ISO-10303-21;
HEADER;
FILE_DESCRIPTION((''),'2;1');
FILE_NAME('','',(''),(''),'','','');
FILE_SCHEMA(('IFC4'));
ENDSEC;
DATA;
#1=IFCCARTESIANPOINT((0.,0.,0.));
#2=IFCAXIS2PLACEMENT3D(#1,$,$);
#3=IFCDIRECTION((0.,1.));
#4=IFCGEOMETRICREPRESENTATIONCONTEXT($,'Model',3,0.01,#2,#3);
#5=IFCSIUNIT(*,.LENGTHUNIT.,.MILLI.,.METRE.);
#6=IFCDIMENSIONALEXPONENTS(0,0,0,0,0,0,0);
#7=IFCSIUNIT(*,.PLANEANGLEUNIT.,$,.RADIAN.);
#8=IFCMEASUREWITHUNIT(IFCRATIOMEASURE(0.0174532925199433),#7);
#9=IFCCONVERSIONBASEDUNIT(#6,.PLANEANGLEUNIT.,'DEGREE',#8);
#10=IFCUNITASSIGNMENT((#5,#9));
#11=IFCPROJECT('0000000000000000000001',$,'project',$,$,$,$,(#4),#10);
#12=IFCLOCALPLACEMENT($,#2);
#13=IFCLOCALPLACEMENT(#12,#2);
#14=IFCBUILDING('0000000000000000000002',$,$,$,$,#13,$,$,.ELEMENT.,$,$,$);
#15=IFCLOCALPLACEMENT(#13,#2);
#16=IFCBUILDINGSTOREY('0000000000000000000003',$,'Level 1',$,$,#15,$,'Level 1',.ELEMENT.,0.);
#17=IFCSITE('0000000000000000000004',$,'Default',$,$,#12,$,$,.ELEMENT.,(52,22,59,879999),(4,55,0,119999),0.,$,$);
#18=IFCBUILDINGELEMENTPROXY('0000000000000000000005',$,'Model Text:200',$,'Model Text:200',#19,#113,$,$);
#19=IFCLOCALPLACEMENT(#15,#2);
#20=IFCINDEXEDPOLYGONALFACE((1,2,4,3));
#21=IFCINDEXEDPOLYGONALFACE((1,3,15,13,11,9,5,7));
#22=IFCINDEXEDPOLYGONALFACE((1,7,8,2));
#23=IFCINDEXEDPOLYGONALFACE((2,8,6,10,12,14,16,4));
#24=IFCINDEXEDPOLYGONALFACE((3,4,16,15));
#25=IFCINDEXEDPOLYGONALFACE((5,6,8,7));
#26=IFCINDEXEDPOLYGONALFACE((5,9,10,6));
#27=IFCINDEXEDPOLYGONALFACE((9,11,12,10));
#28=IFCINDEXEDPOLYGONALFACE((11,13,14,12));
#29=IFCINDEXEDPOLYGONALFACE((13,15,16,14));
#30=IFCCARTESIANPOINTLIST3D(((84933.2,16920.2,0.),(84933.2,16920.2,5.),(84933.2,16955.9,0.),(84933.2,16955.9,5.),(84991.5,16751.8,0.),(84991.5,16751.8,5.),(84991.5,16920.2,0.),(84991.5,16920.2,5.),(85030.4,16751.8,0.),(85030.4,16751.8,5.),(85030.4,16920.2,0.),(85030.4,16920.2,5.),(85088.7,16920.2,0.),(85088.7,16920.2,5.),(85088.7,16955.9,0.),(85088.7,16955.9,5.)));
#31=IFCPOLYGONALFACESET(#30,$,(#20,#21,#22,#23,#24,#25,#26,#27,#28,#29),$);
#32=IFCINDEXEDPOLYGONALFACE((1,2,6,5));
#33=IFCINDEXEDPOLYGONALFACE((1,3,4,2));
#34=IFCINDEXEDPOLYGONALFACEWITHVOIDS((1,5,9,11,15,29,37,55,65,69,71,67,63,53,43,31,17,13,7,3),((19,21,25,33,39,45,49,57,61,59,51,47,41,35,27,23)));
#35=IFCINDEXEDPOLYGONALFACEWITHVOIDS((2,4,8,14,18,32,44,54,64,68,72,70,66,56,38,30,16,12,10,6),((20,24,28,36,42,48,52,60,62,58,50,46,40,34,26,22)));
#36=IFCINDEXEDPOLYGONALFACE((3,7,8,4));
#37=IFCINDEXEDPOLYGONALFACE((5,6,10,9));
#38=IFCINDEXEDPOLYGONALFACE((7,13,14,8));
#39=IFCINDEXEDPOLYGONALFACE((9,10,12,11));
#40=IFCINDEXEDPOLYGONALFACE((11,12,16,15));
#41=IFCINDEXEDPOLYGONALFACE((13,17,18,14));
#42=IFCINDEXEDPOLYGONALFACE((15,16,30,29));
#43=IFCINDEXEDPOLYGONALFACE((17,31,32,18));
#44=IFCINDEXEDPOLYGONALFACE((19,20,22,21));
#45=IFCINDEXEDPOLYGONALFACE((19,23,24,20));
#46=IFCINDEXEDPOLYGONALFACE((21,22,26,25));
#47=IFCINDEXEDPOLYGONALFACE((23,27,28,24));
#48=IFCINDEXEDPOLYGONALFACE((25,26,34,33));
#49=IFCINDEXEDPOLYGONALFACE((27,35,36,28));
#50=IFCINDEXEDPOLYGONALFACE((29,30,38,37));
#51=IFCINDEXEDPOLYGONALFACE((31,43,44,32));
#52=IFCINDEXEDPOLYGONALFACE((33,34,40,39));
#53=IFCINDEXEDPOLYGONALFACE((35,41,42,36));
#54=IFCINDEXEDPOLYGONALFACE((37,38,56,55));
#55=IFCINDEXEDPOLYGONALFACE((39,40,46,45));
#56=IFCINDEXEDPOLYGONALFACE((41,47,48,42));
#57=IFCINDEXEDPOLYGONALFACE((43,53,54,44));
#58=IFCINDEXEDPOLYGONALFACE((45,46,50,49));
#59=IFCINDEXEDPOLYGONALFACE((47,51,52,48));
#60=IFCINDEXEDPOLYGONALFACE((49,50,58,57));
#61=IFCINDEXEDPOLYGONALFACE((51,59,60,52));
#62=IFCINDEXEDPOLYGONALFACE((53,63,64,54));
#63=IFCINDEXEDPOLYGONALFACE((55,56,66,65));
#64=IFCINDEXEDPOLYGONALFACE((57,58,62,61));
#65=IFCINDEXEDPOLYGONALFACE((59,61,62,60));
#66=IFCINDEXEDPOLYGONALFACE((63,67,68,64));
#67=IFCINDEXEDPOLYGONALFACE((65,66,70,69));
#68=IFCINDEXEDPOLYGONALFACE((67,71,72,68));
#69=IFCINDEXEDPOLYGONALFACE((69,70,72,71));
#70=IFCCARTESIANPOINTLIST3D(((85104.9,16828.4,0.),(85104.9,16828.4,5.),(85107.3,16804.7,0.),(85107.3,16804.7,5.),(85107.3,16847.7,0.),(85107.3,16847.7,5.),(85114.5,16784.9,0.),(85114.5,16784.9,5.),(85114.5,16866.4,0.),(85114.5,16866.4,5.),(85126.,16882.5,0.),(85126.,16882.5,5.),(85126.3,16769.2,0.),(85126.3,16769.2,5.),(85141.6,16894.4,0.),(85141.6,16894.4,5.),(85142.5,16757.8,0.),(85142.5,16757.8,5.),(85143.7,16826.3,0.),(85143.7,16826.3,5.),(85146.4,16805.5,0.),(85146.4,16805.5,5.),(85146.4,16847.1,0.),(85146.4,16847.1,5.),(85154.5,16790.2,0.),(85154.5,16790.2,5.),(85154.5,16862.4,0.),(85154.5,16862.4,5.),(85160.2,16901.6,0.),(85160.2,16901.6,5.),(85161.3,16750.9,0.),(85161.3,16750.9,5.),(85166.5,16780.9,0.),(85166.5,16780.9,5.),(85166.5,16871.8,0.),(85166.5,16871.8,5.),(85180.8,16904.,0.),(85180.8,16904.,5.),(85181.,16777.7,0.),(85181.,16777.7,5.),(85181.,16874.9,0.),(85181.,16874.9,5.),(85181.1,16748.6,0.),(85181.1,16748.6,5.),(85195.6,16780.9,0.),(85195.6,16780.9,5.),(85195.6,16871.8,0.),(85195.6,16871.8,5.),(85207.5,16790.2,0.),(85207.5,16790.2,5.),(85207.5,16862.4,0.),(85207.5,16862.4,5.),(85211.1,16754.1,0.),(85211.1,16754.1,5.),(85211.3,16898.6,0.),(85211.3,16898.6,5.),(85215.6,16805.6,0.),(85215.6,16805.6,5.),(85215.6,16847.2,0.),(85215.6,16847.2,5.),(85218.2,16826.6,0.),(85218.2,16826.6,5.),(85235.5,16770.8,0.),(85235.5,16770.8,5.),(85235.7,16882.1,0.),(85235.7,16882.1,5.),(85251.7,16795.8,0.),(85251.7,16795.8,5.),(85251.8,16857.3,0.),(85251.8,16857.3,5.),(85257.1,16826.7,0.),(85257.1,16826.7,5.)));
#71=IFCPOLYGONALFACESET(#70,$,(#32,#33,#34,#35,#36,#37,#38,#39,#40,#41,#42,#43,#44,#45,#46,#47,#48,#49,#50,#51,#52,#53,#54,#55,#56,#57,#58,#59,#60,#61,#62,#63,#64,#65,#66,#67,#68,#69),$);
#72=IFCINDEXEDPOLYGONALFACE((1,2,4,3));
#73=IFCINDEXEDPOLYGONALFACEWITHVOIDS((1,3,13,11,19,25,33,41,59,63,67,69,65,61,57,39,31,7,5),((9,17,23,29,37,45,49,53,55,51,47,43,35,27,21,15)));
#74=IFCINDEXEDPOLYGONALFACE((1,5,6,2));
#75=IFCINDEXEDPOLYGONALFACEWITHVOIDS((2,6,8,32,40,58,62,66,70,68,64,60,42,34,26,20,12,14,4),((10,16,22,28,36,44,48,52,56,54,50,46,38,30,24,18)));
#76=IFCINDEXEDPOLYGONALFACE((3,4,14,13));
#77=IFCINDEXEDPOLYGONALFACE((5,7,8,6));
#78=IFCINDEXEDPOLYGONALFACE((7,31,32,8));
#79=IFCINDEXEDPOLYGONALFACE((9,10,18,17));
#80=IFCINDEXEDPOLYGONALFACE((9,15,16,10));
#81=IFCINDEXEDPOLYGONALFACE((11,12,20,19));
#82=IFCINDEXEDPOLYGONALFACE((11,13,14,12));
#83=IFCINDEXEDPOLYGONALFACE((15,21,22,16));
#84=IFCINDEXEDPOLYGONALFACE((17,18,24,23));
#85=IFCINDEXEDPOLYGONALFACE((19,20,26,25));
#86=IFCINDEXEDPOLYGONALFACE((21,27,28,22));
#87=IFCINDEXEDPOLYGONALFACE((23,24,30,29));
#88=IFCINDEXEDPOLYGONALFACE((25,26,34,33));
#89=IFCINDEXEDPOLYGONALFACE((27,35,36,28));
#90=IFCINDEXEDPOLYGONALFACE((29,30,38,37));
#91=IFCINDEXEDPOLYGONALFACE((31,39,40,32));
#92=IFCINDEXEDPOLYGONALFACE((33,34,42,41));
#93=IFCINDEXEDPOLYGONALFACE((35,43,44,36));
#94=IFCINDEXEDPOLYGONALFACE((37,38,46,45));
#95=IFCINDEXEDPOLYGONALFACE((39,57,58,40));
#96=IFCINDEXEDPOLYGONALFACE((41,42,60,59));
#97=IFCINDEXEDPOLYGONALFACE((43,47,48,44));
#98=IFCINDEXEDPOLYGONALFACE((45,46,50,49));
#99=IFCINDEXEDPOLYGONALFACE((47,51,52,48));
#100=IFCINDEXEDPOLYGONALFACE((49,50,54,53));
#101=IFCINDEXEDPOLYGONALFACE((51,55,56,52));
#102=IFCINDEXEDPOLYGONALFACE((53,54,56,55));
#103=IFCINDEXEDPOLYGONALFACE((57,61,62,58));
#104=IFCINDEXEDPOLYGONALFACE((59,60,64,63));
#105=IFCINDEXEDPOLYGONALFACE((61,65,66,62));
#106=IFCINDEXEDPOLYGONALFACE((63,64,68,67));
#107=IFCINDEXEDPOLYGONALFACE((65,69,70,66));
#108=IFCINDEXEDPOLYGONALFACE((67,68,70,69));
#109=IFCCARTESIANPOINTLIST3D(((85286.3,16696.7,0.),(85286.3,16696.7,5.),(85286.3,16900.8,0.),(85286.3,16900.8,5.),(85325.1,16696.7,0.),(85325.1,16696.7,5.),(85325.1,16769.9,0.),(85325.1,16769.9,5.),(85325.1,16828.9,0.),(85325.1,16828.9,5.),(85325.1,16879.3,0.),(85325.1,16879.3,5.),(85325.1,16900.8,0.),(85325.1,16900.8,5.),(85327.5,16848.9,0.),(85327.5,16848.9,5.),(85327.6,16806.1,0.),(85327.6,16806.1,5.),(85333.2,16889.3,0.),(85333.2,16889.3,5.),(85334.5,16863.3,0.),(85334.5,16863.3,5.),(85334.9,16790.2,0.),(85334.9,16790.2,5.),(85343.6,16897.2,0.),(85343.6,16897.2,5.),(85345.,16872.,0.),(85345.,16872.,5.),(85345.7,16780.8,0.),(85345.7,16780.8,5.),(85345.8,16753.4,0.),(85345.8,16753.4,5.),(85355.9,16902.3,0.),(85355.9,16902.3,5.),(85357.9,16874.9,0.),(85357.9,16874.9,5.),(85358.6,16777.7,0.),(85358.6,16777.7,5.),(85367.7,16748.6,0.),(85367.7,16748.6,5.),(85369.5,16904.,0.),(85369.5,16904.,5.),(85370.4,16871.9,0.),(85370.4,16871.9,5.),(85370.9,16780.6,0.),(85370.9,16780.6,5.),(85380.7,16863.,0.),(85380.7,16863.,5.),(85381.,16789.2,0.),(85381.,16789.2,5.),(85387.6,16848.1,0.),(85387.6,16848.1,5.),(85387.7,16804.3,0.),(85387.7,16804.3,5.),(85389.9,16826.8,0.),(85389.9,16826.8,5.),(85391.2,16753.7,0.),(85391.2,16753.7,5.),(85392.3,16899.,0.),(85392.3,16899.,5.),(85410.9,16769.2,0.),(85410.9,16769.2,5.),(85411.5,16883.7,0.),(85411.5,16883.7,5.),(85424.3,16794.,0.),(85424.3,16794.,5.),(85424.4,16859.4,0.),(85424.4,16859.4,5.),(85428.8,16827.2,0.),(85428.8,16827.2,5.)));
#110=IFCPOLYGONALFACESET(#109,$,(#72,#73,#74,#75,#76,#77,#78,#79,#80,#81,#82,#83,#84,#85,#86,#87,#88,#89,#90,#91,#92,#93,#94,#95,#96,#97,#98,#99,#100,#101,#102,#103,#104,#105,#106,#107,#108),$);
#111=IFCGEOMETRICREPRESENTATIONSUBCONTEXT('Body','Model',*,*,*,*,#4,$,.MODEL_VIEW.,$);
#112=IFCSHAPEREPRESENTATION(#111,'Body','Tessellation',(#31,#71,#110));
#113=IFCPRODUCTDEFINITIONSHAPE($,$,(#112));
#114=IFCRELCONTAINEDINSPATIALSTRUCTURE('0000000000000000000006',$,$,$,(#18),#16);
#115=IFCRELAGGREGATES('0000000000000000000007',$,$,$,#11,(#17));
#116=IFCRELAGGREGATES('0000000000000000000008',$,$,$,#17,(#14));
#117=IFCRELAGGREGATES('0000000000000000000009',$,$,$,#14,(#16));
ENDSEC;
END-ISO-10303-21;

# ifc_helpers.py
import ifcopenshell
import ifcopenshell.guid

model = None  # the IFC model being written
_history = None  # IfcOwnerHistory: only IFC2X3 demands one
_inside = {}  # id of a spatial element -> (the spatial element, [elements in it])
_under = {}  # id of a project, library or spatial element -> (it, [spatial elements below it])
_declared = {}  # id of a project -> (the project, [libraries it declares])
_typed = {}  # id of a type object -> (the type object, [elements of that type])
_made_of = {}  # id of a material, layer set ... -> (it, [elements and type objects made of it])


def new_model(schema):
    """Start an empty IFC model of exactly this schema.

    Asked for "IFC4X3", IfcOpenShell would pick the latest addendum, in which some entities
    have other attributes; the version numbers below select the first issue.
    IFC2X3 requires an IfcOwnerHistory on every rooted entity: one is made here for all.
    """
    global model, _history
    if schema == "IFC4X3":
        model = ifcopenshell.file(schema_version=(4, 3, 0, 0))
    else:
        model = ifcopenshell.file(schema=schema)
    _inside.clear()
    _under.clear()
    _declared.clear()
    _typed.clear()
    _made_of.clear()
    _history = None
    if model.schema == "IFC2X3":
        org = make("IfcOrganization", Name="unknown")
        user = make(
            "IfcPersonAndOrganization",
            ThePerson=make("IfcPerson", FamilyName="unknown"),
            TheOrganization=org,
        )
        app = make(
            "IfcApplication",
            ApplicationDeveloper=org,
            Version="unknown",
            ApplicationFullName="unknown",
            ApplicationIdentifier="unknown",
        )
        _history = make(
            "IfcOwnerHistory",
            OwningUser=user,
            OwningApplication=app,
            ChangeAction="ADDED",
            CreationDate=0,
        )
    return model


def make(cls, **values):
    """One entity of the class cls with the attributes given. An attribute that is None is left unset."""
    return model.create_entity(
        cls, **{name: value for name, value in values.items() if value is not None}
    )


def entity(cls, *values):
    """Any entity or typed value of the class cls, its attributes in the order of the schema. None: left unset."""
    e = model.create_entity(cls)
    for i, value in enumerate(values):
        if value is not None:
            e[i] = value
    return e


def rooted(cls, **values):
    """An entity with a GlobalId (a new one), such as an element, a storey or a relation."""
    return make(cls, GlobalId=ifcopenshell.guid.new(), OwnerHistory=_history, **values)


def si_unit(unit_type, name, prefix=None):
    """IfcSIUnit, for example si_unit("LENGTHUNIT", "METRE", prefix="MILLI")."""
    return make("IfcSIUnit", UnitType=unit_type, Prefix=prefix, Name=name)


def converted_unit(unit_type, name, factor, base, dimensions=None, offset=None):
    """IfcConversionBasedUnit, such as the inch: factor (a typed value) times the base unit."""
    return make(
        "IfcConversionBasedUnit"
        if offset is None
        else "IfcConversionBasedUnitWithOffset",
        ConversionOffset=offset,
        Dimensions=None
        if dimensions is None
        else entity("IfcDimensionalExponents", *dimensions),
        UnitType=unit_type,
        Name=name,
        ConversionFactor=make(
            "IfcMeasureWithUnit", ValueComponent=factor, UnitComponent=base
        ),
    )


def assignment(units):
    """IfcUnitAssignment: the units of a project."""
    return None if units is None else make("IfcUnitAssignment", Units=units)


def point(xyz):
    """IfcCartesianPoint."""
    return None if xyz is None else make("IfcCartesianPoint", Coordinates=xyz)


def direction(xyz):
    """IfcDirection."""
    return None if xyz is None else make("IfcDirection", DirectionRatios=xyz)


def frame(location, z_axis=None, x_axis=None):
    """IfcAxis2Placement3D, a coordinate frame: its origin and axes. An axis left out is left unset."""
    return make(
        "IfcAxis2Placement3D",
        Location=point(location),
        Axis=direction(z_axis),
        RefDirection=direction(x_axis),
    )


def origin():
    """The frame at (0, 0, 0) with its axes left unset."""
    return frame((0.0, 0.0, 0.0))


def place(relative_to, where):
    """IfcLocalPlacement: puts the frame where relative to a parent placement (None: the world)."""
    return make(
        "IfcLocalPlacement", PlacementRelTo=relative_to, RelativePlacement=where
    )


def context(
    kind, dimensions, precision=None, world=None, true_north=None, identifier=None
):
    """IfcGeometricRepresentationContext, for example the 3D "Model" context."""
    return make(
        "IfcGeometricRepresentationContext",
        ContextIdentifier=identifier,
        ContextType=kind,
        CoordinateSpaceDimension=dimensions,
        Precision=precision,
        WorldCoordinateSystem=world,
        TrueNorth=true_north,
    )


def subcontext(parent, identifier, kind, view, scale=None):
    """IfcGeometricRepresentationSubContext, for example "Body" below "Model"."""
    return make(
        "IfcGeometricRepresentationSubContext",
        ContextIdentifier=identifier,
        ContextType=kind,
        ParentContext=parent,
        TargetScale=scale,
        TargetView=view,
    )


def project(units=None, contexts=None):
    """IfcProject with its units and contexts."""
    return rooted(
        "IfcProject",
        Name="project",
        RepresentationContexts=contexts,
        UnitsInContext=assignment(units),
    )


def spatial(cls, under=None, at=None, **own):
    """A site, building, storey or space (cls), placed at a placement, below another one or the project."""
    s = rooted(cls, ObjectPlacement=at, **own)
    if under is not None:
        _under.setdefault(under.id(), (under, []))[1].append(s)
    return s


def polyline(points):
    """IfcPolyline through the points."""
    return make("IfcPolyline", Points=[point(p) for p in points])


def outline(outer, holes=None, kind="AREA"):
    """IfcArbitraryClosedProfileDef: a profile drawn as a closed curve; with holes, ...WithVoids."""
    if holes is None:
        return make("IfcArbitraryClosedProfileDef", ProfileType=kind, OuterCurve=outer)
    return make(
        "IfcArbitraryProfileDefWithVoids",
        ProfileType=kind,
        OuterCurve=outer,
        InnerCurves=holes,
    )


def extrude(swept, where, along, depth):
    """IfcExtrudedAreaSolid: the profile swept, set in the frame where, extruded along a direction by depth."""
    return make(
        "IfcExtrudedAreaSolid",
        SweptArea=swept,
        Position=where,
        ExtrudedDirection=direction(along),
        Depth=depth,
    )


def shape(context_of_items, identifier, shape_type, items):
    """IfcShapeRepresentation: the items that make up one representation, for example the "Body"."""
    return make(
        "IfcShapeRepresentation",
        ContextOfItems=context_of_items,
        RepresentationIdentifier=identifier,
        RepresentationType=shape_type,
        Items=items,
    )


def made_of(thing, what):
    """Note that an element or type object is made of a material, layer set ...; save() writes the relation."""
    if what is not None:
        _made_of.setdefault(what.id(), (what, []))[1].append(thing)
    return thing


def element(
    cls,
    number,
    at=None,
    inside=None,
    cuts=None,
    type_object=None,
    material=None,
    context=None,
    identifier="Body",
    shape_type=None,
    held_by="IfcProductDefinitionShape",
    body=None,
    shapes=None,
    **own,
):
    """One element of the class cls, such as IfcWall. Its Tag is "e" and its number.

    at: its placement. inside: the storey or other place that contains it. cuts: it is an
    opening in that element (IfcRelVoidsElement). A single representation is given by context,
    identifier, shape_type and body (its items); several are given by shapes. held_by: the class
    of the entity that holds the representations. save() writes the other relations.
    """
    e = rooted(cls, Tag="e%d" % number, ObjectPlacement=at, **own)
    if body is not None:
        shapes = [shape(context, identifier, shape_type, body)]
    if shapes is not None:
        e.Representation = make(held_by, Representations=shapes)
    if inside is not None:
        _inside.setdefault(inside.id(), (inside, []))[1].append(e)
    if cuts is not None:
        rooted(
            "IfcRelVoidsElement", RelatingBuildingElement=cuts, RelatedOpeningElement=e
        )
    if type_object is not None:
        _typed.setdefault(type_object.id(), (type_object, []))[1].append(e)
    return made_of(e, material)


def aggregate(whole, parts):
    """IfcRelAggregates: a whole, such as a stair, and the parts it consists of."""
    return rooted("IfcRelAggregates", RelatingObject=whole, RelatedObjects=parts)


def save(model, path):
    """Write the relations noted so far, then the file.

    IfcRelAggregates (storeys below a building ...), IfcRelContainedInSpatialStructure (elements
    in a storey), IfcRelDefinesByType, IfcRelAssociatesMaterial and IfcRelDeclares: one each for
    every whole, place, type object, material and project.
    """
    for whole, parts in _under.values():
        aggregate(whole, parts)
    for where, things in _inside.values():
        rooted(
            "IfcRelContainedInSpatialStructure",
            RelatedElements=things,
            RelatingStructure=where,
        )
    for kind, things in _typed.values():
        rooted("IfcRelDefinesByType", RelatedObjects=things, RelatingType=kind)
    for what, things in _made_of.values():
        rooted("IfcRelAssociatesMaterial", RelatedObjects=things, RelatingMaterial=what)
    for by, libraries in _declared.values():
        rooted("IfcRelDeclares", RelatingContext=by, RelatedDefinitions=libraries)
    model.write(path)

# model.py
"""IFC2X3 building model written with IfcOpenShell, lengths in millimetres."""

from ifc_helpers import new_model, entity, si_unit, converted_unit, direction, frame, origin, place, context, subcontext, project, spatial, polyline, outline, extrude, element, save


model = new_model("IFC2X3")

# Units and contexts
model_context = context("Model", 3, precision=0.01, world=origin(), true_north=direction((0.0, 1.0)))
body_context = subcontext(model_context, "Body", "Model", "MODEL_VIEW")
ifc_project = project(units=[si_unit("LENGTHUNIT", "METRE", prefix="MILLI"), converted_unit("PLANEANGLEUNIT", "DEGREE", entity("IfcRatioMeasure", 0.0174532925199433), si_unit("PLANEANGLEUNIT", "RADIAN"), dimensions=[0, 0, 0, 0, 0, 0, 0])], contexts=[model_context])

# Site, building, storey
site_placement = place(None, origin())
site = spatial("IfcSite", under=ifc_project, at=site_placement, Name="Default", CompositionType="ELEMENT", RefLatitude=(52, 22, 59, 879999), RefLongitude=(4, 55, 0, 119999), RefElevation=0.0)
building_placement = place(site_placement, origin())
building = spatial("IfcBuilding", under=site, at=building_placement, CompositionType="ELEMENT")
storey_placement = place(building_placement, origin())
storey = spatial("IfcBuildingStorey", under=building, at=storey_placement, Name="Level 1", LongName="Level 1", CompositionType="ELEMENT", Elevation=0.0)

# Building element proxy
proxy_1_placement = place(building_placement, origin())
element("IfcBuildingElementProxy", 1, at=proxy_1_placement, inside=storey, Name="Model Text:200", ObjectType="Model Text:200", context=body_context, shape_type="SweptSolid", body=[
    extrude(outline(polyline([(-19.4, -135.2), (19.4, -135.2), (19.4, 33.2), (77.7, 33.2), (77.7, 68.8), (-77.7, 68.8), (-77.7, 33.2), (-19.4, 33.2), (-19.4, -135.2)])), frame((85010.9, 16887.0, 0.0)), (0.0, 0.0, 1.0), 5.0),
    extrude(outline(polyline([(-8.8, -65.7), (15.1, -65.7), (35.5, -60.5), (52.3, -50.4), (65.3, -35.4), (74.1, -17.3), (78.4, 2.1), (75.9, 32.5), (61.8, 58.5), (38.4, 77.1), (8.3, 85.6), (-22.7, 83.3), (-49.0, 69.9), (-67.8, 47.3), (-76.3, 17.5), (-76.0, -3.3), (-70.7, -22.5), (-60.5, -39.2), (-45.5, -52.3), (-27.7, -61.4), (-8.8, -65.7)]), holes=[polyline([(-2.7, -27.2), (-23.1, -22.5), (-37.5, -12.9), (-45.7, 0.0), (-47.3, 14.8), (-42.7, 28.9), (-32.2, 39.9), (-16.3, 46.3), (4.5, 46.9), (25.1, 42.1), (39.6, 32.6), (47.7, 19.7), (49.4, 5.0), (44.8, -9.2), (34.2, -20.2), (18.2, -26.7), (-2.7, -27.2)])]), frame((85171.1, 16826.3, 0.0), z_axis=(0.0, 0.0, 1.0), x_axis=(0.100608, -0.994926, 0.0)), (0.0, 0.0, 1.0), 5.0),
    extrude(outline(polyline([(-73.1, -75.4), (130.9, -75.4), (130.9, -36.6), (57.8, -36.6), (74.3, -15.9), (79.1, 6.0), (73.9, 29.5), (58.4, 49.2), (33.6, 62.6), (0.5, 67.1), (-31.8, 62.8), (-56.1, 49.8), (-71.3, 30.7), (-76.4, 7.8), (-74.7, -5.8), (-69.6, -18.1), (-61.7, -28.5), (-51.7, -36.6), (-73.1, -36.6), (-73.1, -75.4)]), holes=[polyline([(-1.2, -36.6), (-21.2, -34.2), (-35.6, -27.2), (-44.3, -16.7), (-47.2, -3.8), (-44.3, 8.7), (-35.4, 19.0), (-20.4, 25.9), (0.8, 28.2), (23.3, 26.0), (38.5, 19.3), (47.1, 9.2), (49.9, -3.1), (46.8, -16.0), (37.4, -26.8), (21.5, -34.1), (-1.2, -36.6)])]), frame((85361.7, 16827.7, 0.0), z_axis=(0.0, 0.0, 1.0), x_axis=(0.0, -1.0, 0.0)), (0.0, 0.0, 1.0), 5.0),
])

save(model, "model.ifc")
